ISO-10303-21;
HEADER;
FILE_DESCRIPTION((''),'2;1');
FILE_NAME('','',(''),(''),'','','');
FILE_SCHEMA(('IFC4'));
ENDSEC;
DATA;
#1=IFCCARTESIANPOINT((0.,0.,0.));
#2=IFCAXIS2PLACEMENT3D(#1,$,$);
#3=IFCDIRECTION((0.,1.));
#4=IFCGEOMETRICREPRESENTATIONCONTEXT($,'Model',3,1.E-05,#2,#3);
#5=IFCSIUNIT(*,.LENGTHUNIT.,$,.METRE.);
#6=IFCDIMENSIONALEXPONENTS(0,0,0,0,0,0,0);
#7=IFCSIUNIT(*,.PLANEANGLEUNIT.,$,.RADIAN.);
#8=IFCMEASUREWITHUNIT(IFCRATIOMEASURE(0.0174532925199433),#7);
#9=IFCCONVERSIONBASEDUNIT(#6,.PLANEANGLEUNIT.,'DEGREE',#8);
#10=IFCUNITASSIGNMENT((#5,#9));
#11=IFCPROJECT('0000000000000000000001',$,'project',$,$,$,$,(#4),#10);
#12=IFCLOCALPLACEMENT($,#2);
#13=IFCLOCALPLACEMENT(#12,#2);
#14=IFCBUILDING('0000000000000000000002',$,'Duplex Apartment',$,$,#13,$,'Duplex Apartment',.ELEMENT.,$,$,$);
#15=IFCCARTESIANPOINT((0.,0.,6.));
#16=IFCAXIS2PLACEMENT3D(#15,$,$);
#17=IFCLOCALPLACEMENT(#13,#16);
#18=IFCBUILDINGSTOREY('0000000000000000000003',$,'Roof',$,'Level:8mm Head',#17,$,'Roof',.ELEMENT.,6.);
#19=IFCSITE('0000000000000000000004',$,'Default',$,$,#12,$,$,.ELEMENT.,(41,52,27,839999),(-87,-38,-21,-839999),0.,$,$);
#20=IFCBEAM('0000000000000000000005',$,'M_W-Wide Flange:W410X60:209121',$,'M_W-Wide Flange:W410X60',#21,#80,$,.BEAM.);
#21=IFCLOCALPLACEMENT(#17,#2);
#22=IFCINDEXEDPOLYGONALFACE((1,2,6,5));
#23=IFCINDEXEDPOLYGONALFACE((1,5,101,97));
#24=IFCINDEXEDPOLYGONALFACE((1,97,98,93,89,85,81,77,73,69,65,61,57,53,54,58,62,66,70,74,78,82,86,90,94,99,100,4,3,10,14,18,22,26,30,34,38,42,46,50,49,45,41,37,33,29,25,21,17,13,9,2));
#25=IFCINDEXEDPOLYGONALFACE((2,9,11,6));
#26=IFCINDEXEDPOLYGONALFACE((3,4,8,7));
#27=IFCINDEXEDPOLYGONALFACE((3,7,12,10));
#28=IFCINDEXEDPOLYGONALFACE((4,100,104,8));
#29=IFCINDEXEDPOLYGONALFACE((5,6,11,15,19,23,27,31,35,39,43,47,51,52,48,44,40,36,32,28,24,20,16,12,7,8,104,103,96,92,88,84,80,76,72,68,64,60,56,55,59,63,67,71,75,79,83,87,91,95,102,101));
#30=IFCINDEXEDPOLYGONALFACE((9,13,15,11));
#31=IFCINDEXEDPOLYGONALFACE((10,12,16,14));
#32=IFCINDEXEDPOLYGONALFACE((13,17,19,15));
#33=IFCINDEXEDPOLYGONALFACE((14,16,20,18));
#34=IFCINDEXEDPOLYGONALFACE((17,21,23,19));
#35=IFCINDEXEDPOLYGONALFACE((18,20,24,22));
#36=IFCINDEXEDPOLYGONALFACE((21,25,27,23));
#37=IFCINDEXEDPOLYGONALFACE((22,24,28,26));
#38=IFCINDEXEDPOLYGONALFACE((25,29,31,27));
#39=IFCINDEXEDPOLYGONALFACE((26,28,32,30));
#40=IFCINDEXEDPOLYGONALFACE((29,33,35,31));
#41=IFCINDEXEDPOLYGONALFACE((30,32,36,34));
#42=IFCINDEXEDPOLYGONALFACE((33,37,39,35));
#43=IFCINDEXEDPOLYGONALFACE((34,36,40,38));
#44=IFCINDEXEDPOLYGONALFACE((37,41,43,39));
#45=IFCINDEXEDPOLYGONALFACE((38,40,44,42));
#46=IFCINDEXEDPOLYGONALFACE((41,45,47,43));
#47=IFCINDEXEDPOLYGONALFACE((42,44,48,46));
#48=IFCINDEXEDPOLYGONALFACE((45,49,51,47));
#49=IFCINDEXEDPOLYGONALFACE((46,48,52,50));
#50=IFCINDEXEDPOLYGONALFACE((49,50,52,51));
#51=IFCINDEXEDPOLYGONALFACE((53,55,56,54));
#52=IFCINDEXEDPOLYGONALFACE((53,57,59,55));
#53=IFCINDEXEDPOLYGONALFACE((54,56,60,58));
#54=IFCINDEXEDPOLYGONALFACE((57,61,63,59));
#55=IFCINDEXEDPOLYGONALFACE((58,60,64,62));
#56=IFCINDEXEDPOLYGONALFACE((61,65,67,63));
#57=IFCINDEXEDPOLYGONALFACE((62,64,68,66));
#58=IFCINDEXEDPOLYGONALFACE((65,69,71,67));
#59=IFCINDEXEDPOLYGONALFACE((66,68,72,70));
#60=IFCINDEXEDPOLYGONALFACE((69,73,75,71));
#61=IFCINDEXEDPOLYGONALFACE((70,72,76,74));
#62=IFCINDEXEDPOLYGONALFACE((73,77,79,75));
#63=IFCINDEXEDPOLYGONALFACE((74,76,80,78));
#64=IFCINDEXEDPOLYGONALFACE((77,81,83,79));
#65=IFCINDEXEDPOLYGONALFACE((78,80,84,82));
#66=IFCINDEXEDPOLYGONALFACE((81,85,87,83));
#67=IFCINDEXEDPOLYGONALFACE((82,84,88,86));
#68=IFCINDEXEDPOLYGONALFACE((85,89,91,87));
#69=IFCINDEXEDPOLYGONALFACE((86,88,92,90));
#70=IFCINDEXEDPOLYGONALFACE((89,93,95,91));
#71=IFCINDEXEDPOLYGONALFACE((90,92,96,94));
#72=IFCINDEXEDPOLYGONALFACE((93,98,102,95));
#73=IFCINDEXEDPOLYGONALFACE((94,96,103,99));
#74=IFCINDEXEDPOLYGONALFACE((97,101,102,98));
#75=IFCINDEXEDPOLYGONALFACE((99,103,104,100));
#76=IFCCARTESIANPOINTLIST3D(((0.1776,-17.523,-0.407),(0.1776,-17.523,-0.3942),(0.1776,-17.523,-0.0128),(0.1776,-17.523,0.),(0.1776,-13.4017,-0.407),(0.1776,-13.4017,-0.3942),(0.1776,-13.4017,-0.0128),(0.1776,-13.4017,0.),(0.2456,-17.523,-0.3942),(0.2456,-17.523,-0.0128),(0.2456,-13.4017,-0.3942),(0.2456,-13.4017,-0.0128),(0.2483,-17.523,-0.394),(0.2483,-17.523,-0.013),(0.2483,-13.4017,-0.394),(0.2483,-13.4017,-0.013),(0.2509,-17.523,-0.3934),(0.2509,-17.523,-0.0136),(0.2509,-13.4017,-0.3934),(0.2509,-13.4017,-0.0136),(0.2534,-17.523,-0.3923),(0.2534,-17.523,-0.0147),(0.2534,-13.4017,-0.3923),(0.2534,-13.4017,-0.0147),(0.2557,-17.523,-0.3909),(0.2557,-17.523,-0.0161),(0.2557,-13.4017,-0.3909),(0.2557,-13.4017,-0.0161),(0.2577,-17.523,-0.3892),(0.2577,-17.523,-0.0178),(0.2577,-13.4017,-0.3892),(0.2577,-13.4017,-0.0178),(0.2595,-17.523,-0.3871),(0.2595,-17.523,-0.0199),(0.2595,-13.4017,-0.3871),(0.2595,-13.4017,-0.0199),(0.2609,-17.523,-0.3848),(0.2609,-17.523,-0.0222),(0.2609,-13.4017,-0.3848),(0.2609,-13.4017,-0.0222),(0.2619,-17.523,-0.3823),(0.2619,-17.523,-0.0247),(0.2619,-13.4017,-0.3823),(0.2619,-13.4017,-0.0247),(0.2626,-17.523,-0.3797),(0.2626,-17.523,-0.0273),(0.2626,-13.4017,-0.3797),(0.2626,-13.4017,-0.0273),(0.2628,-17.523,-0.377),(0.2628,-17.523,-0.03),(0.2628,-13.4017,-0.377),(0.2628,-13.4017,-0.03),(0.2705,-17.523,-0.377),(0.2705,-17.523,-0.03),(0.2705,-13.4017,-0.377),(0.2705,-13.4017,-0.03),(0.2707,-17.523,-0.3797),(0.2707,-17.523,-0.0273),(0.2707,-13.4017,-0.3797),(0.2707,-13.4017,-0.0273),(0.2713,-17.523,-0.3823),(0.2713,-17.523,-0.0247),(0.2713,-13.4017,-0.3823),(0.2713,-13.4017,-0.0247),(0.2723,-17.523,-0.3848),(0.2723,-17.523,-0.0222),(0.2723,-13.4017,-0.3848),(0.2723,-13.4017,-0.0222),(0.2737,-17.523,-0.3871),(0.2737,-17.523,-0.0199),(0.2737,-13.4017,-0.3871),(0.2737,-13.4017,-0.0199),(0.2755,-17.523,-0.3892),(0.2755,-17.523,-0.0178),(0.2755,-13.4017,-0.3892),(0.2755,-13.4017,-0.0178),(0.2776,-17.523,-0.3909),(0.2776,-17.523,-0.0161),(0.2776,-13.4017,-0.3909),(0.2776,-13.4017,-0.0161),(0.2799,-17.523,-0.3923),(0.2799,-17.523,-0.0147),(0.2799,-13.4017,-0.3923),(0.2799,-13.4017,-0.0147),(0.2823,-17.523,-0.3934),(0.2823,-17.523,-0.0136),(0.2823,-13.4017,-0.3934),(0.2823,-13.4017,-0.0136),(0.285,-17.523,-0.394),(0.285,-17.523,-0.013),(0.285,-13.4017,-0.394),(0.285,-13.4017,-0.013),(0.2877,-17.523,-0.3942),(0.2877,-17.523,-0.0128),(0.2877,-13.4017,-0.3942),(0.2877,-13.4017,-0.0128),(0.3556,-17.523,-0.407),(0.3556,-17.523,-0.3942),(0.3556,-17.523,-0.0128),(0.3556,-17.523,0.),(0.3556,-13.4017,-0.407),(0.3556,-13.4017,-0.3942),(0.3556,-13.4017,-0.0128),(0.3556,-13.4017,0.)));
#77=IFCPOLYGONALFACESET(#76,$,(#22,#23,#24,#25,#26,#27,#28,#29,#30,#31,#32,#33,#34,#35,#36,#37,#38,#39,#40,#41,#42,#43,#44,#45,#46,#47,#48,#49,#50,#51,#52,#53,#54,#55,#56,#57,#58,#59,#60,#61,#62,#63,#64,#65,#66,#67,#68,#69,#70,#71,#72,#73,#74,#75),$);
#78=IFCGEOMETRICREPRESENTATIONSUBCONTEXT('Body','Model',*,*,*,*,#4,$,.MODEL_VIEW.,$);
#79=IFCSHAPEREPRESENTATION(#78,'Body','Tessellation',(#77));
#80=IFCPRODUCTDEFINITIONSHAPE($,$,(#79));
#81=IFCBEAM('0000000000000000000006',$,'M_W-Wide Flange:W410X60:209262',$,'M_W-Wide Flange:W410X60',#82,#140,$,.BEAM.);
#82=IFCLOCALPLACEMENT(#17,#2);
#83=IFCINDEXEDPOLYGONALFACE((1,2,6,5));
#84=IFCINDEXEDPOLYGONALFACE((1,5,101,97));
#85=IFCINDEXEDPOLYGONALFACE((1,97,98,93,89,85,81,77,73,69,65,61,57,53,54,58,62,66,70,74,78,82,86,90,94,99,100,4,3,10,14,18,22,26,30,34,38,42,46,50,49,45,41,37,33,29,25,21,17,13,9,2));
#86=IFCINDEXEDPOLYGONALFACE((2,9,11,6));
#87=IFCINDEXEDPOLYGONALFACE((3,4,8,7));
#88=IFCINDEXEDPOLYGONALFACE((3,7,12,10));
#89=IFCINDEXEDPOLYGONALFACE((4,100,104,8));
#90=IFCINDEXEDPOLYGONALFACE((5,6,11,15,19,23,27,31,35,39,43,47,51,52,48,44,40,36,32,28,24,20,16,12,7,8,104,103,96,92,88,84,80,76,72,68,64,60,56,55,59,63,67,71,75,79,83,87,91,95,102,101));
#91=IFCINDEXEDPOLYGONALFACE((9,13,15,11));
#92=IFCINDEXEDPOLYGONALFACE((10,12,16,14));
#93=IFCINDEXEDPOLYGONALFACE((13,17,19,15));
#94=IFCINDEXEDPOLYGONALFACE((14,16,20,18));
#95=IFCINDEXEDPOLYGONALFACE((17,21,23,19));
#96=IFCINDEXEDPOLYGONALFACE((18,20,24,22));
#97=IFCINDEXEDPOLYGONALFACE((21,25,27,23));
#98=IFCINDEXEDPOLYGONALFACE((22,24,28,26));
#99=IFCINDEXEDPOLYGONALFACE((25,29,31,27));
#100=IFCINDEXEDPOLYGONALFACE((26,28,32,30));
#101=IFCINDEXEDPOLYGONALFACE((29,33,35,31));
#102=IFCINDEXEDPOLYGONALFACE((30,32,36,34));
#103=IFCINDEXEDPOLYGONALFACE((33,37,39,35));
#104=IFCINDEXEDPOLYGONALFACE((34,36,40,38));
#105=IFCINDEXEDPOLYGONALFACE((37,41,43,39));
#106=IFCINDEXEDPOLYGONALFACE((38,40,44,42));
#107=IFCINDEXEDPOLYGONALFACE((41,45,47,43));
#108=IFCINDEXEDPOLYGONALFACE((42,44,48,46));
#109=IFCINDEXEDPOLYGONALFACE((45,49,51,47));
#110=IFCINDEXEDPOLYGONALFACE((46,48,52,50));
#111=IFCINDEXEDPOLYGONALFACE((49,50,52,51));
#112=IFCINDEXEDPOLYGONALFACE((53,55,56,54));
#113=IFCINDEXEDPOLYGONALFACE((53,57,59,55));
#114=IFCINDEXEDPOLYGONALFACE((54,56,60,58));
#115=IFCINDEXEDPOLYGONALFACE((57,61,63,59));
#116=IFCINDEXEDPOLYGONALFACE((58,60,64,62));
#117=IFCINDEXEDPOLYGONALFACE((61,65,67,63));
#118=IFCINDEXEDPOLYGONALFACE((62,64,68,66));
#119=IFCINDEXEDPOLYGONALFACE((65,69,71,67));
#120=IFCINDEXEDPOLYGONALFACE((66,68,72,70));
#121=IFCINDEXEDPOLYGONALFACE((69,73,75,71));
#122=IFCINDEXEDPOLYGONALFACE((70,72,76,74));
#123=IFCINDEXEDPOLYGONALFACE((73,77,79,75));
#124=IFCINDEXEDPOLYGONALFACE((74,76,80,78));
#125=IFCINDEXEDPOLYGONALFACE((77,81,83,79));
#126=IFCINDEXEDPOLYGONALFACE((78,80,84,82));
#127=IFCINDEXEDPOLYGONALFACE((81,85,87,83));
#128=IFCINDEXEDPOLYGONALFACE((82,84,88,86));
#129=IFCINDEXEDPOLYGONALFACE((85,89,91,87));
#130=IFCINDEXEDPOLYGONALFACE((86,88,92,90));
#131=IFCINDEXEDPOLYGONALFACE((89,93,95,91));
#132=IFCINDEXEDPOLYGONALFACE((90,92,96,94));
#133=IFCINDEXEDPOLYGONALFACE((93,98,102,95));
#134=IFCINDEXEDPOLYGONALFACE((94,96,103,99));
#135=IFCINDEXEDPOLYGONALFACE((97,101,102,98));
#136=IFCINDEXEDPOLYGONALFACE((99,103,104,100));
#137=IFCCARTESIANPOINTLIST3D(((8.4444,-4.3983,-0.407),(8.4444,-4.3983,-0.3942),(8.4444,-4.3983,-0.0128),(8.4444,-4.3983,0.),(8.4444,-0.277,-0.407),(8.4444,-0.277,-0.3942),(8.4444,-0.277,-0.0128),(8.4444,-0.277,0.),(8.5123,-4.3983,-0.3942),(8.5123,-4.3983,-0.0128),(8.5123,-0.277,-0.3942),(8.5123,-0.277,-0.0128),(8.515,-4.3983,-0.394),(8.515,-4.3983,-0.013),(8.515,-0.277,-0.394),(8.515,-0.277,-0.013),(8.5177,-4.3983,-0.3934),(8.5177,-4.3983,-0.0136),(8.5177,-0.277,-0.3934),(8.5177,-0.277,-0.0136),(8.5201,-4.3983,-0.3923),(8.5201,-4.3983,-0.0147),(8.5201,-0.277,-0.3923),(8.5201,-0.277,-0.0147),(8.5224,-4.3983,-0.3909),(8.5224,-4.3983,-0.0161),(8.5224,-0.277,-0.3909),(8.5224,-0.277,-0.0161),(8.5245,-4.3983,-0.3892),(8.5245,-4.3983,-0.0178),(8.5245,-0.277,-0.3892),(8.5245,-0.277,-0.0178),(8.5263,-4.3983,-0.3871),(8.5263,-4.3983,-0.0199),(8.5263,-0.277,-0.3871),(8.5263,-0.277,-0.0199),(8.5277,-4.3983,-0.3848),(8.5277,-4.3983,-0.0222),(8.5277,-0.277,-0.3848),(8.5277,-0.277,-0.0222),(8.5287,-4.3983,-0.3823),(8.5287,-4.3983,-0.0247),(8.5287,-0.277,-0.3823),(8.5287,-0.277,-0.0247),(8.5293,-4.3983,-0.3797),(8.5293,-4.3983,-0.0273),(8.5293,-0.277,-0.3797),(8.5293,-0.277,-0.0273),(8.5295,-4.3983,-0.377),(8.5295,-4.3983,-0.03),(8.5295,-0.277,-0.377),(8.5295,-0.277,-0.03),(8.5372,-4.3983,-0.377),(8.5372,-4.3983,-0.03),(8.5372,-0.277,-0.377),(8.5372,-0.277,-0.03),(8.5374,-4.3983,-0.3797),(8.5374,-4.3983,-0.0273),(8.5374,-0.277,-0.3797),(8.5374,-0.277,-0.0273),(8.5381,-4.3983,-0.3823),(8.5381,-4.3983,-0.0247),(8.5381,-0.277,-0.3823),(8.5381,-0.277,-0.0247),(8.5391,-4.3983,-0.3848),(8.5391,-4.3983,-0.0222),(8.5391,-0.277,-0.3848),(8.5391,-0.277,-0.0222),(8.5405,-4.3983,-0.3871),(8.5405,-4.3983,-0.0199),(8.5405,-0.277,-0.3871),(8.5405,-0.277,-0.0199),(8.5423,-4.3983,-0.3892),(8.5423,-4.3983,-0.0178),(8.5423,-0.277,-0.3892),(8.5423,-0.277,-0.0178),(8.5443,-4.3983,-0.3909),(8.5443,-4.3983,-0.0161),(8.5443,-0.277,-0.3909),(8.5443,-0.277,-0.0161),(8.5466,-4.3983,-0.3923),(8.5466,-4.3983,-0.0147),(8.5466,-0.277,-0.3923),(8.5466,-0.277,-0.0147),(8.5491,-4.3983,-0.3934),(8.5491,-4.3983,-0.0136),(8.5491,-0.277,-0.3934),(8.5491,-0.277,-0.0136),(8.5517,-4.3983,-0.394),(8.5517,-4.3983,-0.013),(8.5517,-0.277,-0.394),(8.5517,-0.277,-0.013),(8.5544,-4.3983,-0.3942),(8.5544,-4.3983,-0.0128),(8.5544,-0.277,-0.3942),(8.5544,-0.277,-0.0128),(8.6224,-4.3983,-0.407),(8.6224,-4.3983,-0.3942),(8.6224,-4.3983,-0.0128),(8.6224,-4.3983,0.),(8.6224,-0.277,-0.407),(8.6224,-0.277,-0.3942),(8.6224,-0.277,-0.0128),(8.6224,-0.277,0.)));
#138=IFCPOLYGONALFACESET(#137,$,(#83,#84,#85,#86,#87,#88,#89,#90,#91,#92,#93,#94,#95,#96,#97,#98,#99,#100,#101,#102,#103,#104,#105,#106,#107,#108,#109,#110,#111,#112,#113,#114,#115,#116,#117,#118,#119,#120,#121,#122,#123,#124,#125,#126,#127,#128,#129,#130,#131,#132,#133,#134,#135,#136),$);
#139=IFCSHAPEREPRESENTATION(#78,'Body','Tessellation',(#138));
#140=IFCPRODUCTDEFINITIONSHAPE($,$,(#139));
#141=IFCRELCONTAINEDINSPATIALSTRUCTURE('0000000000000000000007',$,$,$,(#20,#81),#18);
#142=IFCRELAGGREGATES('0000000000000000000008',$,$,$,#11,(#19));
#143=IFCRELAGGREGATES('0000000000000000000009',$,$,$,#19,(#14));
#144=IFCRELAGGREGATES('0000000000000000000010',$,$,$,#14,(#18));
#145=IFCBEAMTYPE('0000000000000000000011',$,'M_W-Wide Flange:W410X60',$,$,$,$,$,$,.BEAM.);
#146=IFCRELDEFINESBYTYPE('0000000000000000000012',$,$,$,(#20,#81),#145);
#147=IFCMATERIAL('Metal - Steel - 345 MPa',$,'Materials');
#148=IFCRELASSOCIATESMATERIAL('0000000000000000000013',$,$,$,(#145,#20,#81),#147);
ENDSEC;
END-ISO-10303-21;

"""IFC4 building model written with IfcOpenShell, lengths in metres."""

from ifc_helpers import new_model, entity, si_unit, converted_unit, direction, frame, origin, place, context, subcontext, project, spatial, indexed_curve, outline, extrude, source, transform, mapped, material, type_object, type_shapes, element, save


model = new_model("IFC4")

# Units and contexts
model_context = context("Model", 3, precision=1e-05, world=origin(), true_north=direction((0.0, 1.0)))
body_context = subcontext(model_context, "Body", "Model", "MODEL_VIEW")
ifc_project = project(units=[si_unit("LENGTHUNIT", "METRE"), converted_unit("PLANEANGLEUNIT", "DEGREE", entity("IfcRatioMeasure", 0.0174532925199433), si_unit("PLANEANGLEUNIT", "RADIAN"), dimensions=[0, 0, 0, 0, 0, 0, 0])], contexts=[model_context])

# Site, building, storey
site_placement = place(None, origin())
site = spatial("IfcSite", under=ifc_project, at=site_placement, Name="Default", CompositionType="ELEMENT", RefLatitude=(41, 52, 27, 839999), RefLongitude=(-87, -38, -21, -839999), RefElevation=0.0)
building_placement = place(site_placement, origin())
building = spatial("IfcBuilding", under=site, at=building_placement, Name="Duplex Apartment", LongName="Duplex Apartment", CompositionType="ELEMENT")
storey_placement = place(building_placement, frame((0.0, 0.0, 6.0)))
storey = spatial("IfcBuildingStorey", under=building, at=storey_placement, Name="Roof", ObjectType="Level:8mm Head", LongName="Roof", CompositionType="ELEMENT", Elevation=6.0)

# Beams
ifc_material_1 = material(Name="Metal - Steel - 345 MPa", Category="Materials")
beam_type_1 = type_object("IfcBeamType", Name="M_W-Wide Flange:W410X60", PredefinedType="BEAM", material=ifc_material_1)
shared_shape_1 = source(origin(), body_context, "Body", "SweptSolid", [
    extrude(outline(indexed_curve([(-0.2035, -0.089), (-0.1907, -0.089), (-0.1907, -0.021), (-0.1905, -0.0184), (-0.1899, -0.0157), (-0.1888, -0.0132), (-0.1874, -0.0109), (-0.1857, -0.0089), (-0.1836, -0.0071), (-0.1813, -0.0057), (-0.1788, -0.0047), (-0.1762, -0.0041), (-0.1735, -0.0038), (0.1735, -0.0038), (0.1762, -0.0041), (0.1788, -0.0047), (0.1813, -0.0057), (0.1836, -0.0071), (0.1857, -0.0089), (0.1874, -0.0109), (0.1888, -0.0132), (0.1899, -0.0157), (0.1905, -0.0184), (0.1907, -0.021), (0.1907, -0.089), (0.2035, -0.089), (0.2035, 0.089), (0.1907, 0.089), (0.1907, 0.0211), (0.1905, 0.0184), (0.1899, 0.0157), (0.1888, 0.0132), (0.1874, 0.0109), (0.1857, 0.0089), (0.1836, 0.0071), (0.1813, 0.0057), (0.1788, 0.0047), (0.1762, 0.0041), (0.1735, 0.0039), (-0.1735, 0.0039), (-0.1762, 0.0041), (-0.1788, 0.0047), (-0.1813, 0.0057), (-0.1836, 0.0071), (-0.1857, 0.0089), (-0.1874, 0.0109), (-0.1888, 0.0132), (-0.1899, 0.0157), (-0.1905, 0.0184), (-0.1907, 0.0211), (-0.1907, 0.089), (-0.2035, 0.089), (-0.2035, -0.089)], self_intersect=False)), frame((-2.0606, 0.0, 0.0), z_axis=(1.0, 0.0, 0.0), x_axis=(0.0, 0.0, -1.0)), (0.0, 0.0, 1.0), 4.1213),
])
type_shapes(beam_type_1, [shared_shape_1])
for number, where, z_axis, x_axis, name in (
    (1, (0.2666, -15.4624, -0.2035), (0.0, 0.0, 1.0), (0.0, -1.0, 0.0), "M_W-Wide Flange:W410X60:209121"),
    (2, (8.5334, -2.3376, -0.2035), (0.0, 0.0, 1.0), (0.0, 1.0, 0.0), "M_W-Wide Flange:W410X60:209262"),
):
    element("IfcBeam", number, at=place(storey_placement, frame(where, z_axis=z_axis, x_axis=x_axis)), inside=storey, type_object=beam_type_1, material=ifc_material_1, Name=name, ObjectType="M_W-Wide Flange:W410X60", PredefinedType="BEAM", context=body_context, shape_type="MappedRepresentation", body=[
        mapped(shared_shape_1, transform((0.0, 0.0, 0.0), scale=1.0)),
    ])

save(model, "model.ifc")
